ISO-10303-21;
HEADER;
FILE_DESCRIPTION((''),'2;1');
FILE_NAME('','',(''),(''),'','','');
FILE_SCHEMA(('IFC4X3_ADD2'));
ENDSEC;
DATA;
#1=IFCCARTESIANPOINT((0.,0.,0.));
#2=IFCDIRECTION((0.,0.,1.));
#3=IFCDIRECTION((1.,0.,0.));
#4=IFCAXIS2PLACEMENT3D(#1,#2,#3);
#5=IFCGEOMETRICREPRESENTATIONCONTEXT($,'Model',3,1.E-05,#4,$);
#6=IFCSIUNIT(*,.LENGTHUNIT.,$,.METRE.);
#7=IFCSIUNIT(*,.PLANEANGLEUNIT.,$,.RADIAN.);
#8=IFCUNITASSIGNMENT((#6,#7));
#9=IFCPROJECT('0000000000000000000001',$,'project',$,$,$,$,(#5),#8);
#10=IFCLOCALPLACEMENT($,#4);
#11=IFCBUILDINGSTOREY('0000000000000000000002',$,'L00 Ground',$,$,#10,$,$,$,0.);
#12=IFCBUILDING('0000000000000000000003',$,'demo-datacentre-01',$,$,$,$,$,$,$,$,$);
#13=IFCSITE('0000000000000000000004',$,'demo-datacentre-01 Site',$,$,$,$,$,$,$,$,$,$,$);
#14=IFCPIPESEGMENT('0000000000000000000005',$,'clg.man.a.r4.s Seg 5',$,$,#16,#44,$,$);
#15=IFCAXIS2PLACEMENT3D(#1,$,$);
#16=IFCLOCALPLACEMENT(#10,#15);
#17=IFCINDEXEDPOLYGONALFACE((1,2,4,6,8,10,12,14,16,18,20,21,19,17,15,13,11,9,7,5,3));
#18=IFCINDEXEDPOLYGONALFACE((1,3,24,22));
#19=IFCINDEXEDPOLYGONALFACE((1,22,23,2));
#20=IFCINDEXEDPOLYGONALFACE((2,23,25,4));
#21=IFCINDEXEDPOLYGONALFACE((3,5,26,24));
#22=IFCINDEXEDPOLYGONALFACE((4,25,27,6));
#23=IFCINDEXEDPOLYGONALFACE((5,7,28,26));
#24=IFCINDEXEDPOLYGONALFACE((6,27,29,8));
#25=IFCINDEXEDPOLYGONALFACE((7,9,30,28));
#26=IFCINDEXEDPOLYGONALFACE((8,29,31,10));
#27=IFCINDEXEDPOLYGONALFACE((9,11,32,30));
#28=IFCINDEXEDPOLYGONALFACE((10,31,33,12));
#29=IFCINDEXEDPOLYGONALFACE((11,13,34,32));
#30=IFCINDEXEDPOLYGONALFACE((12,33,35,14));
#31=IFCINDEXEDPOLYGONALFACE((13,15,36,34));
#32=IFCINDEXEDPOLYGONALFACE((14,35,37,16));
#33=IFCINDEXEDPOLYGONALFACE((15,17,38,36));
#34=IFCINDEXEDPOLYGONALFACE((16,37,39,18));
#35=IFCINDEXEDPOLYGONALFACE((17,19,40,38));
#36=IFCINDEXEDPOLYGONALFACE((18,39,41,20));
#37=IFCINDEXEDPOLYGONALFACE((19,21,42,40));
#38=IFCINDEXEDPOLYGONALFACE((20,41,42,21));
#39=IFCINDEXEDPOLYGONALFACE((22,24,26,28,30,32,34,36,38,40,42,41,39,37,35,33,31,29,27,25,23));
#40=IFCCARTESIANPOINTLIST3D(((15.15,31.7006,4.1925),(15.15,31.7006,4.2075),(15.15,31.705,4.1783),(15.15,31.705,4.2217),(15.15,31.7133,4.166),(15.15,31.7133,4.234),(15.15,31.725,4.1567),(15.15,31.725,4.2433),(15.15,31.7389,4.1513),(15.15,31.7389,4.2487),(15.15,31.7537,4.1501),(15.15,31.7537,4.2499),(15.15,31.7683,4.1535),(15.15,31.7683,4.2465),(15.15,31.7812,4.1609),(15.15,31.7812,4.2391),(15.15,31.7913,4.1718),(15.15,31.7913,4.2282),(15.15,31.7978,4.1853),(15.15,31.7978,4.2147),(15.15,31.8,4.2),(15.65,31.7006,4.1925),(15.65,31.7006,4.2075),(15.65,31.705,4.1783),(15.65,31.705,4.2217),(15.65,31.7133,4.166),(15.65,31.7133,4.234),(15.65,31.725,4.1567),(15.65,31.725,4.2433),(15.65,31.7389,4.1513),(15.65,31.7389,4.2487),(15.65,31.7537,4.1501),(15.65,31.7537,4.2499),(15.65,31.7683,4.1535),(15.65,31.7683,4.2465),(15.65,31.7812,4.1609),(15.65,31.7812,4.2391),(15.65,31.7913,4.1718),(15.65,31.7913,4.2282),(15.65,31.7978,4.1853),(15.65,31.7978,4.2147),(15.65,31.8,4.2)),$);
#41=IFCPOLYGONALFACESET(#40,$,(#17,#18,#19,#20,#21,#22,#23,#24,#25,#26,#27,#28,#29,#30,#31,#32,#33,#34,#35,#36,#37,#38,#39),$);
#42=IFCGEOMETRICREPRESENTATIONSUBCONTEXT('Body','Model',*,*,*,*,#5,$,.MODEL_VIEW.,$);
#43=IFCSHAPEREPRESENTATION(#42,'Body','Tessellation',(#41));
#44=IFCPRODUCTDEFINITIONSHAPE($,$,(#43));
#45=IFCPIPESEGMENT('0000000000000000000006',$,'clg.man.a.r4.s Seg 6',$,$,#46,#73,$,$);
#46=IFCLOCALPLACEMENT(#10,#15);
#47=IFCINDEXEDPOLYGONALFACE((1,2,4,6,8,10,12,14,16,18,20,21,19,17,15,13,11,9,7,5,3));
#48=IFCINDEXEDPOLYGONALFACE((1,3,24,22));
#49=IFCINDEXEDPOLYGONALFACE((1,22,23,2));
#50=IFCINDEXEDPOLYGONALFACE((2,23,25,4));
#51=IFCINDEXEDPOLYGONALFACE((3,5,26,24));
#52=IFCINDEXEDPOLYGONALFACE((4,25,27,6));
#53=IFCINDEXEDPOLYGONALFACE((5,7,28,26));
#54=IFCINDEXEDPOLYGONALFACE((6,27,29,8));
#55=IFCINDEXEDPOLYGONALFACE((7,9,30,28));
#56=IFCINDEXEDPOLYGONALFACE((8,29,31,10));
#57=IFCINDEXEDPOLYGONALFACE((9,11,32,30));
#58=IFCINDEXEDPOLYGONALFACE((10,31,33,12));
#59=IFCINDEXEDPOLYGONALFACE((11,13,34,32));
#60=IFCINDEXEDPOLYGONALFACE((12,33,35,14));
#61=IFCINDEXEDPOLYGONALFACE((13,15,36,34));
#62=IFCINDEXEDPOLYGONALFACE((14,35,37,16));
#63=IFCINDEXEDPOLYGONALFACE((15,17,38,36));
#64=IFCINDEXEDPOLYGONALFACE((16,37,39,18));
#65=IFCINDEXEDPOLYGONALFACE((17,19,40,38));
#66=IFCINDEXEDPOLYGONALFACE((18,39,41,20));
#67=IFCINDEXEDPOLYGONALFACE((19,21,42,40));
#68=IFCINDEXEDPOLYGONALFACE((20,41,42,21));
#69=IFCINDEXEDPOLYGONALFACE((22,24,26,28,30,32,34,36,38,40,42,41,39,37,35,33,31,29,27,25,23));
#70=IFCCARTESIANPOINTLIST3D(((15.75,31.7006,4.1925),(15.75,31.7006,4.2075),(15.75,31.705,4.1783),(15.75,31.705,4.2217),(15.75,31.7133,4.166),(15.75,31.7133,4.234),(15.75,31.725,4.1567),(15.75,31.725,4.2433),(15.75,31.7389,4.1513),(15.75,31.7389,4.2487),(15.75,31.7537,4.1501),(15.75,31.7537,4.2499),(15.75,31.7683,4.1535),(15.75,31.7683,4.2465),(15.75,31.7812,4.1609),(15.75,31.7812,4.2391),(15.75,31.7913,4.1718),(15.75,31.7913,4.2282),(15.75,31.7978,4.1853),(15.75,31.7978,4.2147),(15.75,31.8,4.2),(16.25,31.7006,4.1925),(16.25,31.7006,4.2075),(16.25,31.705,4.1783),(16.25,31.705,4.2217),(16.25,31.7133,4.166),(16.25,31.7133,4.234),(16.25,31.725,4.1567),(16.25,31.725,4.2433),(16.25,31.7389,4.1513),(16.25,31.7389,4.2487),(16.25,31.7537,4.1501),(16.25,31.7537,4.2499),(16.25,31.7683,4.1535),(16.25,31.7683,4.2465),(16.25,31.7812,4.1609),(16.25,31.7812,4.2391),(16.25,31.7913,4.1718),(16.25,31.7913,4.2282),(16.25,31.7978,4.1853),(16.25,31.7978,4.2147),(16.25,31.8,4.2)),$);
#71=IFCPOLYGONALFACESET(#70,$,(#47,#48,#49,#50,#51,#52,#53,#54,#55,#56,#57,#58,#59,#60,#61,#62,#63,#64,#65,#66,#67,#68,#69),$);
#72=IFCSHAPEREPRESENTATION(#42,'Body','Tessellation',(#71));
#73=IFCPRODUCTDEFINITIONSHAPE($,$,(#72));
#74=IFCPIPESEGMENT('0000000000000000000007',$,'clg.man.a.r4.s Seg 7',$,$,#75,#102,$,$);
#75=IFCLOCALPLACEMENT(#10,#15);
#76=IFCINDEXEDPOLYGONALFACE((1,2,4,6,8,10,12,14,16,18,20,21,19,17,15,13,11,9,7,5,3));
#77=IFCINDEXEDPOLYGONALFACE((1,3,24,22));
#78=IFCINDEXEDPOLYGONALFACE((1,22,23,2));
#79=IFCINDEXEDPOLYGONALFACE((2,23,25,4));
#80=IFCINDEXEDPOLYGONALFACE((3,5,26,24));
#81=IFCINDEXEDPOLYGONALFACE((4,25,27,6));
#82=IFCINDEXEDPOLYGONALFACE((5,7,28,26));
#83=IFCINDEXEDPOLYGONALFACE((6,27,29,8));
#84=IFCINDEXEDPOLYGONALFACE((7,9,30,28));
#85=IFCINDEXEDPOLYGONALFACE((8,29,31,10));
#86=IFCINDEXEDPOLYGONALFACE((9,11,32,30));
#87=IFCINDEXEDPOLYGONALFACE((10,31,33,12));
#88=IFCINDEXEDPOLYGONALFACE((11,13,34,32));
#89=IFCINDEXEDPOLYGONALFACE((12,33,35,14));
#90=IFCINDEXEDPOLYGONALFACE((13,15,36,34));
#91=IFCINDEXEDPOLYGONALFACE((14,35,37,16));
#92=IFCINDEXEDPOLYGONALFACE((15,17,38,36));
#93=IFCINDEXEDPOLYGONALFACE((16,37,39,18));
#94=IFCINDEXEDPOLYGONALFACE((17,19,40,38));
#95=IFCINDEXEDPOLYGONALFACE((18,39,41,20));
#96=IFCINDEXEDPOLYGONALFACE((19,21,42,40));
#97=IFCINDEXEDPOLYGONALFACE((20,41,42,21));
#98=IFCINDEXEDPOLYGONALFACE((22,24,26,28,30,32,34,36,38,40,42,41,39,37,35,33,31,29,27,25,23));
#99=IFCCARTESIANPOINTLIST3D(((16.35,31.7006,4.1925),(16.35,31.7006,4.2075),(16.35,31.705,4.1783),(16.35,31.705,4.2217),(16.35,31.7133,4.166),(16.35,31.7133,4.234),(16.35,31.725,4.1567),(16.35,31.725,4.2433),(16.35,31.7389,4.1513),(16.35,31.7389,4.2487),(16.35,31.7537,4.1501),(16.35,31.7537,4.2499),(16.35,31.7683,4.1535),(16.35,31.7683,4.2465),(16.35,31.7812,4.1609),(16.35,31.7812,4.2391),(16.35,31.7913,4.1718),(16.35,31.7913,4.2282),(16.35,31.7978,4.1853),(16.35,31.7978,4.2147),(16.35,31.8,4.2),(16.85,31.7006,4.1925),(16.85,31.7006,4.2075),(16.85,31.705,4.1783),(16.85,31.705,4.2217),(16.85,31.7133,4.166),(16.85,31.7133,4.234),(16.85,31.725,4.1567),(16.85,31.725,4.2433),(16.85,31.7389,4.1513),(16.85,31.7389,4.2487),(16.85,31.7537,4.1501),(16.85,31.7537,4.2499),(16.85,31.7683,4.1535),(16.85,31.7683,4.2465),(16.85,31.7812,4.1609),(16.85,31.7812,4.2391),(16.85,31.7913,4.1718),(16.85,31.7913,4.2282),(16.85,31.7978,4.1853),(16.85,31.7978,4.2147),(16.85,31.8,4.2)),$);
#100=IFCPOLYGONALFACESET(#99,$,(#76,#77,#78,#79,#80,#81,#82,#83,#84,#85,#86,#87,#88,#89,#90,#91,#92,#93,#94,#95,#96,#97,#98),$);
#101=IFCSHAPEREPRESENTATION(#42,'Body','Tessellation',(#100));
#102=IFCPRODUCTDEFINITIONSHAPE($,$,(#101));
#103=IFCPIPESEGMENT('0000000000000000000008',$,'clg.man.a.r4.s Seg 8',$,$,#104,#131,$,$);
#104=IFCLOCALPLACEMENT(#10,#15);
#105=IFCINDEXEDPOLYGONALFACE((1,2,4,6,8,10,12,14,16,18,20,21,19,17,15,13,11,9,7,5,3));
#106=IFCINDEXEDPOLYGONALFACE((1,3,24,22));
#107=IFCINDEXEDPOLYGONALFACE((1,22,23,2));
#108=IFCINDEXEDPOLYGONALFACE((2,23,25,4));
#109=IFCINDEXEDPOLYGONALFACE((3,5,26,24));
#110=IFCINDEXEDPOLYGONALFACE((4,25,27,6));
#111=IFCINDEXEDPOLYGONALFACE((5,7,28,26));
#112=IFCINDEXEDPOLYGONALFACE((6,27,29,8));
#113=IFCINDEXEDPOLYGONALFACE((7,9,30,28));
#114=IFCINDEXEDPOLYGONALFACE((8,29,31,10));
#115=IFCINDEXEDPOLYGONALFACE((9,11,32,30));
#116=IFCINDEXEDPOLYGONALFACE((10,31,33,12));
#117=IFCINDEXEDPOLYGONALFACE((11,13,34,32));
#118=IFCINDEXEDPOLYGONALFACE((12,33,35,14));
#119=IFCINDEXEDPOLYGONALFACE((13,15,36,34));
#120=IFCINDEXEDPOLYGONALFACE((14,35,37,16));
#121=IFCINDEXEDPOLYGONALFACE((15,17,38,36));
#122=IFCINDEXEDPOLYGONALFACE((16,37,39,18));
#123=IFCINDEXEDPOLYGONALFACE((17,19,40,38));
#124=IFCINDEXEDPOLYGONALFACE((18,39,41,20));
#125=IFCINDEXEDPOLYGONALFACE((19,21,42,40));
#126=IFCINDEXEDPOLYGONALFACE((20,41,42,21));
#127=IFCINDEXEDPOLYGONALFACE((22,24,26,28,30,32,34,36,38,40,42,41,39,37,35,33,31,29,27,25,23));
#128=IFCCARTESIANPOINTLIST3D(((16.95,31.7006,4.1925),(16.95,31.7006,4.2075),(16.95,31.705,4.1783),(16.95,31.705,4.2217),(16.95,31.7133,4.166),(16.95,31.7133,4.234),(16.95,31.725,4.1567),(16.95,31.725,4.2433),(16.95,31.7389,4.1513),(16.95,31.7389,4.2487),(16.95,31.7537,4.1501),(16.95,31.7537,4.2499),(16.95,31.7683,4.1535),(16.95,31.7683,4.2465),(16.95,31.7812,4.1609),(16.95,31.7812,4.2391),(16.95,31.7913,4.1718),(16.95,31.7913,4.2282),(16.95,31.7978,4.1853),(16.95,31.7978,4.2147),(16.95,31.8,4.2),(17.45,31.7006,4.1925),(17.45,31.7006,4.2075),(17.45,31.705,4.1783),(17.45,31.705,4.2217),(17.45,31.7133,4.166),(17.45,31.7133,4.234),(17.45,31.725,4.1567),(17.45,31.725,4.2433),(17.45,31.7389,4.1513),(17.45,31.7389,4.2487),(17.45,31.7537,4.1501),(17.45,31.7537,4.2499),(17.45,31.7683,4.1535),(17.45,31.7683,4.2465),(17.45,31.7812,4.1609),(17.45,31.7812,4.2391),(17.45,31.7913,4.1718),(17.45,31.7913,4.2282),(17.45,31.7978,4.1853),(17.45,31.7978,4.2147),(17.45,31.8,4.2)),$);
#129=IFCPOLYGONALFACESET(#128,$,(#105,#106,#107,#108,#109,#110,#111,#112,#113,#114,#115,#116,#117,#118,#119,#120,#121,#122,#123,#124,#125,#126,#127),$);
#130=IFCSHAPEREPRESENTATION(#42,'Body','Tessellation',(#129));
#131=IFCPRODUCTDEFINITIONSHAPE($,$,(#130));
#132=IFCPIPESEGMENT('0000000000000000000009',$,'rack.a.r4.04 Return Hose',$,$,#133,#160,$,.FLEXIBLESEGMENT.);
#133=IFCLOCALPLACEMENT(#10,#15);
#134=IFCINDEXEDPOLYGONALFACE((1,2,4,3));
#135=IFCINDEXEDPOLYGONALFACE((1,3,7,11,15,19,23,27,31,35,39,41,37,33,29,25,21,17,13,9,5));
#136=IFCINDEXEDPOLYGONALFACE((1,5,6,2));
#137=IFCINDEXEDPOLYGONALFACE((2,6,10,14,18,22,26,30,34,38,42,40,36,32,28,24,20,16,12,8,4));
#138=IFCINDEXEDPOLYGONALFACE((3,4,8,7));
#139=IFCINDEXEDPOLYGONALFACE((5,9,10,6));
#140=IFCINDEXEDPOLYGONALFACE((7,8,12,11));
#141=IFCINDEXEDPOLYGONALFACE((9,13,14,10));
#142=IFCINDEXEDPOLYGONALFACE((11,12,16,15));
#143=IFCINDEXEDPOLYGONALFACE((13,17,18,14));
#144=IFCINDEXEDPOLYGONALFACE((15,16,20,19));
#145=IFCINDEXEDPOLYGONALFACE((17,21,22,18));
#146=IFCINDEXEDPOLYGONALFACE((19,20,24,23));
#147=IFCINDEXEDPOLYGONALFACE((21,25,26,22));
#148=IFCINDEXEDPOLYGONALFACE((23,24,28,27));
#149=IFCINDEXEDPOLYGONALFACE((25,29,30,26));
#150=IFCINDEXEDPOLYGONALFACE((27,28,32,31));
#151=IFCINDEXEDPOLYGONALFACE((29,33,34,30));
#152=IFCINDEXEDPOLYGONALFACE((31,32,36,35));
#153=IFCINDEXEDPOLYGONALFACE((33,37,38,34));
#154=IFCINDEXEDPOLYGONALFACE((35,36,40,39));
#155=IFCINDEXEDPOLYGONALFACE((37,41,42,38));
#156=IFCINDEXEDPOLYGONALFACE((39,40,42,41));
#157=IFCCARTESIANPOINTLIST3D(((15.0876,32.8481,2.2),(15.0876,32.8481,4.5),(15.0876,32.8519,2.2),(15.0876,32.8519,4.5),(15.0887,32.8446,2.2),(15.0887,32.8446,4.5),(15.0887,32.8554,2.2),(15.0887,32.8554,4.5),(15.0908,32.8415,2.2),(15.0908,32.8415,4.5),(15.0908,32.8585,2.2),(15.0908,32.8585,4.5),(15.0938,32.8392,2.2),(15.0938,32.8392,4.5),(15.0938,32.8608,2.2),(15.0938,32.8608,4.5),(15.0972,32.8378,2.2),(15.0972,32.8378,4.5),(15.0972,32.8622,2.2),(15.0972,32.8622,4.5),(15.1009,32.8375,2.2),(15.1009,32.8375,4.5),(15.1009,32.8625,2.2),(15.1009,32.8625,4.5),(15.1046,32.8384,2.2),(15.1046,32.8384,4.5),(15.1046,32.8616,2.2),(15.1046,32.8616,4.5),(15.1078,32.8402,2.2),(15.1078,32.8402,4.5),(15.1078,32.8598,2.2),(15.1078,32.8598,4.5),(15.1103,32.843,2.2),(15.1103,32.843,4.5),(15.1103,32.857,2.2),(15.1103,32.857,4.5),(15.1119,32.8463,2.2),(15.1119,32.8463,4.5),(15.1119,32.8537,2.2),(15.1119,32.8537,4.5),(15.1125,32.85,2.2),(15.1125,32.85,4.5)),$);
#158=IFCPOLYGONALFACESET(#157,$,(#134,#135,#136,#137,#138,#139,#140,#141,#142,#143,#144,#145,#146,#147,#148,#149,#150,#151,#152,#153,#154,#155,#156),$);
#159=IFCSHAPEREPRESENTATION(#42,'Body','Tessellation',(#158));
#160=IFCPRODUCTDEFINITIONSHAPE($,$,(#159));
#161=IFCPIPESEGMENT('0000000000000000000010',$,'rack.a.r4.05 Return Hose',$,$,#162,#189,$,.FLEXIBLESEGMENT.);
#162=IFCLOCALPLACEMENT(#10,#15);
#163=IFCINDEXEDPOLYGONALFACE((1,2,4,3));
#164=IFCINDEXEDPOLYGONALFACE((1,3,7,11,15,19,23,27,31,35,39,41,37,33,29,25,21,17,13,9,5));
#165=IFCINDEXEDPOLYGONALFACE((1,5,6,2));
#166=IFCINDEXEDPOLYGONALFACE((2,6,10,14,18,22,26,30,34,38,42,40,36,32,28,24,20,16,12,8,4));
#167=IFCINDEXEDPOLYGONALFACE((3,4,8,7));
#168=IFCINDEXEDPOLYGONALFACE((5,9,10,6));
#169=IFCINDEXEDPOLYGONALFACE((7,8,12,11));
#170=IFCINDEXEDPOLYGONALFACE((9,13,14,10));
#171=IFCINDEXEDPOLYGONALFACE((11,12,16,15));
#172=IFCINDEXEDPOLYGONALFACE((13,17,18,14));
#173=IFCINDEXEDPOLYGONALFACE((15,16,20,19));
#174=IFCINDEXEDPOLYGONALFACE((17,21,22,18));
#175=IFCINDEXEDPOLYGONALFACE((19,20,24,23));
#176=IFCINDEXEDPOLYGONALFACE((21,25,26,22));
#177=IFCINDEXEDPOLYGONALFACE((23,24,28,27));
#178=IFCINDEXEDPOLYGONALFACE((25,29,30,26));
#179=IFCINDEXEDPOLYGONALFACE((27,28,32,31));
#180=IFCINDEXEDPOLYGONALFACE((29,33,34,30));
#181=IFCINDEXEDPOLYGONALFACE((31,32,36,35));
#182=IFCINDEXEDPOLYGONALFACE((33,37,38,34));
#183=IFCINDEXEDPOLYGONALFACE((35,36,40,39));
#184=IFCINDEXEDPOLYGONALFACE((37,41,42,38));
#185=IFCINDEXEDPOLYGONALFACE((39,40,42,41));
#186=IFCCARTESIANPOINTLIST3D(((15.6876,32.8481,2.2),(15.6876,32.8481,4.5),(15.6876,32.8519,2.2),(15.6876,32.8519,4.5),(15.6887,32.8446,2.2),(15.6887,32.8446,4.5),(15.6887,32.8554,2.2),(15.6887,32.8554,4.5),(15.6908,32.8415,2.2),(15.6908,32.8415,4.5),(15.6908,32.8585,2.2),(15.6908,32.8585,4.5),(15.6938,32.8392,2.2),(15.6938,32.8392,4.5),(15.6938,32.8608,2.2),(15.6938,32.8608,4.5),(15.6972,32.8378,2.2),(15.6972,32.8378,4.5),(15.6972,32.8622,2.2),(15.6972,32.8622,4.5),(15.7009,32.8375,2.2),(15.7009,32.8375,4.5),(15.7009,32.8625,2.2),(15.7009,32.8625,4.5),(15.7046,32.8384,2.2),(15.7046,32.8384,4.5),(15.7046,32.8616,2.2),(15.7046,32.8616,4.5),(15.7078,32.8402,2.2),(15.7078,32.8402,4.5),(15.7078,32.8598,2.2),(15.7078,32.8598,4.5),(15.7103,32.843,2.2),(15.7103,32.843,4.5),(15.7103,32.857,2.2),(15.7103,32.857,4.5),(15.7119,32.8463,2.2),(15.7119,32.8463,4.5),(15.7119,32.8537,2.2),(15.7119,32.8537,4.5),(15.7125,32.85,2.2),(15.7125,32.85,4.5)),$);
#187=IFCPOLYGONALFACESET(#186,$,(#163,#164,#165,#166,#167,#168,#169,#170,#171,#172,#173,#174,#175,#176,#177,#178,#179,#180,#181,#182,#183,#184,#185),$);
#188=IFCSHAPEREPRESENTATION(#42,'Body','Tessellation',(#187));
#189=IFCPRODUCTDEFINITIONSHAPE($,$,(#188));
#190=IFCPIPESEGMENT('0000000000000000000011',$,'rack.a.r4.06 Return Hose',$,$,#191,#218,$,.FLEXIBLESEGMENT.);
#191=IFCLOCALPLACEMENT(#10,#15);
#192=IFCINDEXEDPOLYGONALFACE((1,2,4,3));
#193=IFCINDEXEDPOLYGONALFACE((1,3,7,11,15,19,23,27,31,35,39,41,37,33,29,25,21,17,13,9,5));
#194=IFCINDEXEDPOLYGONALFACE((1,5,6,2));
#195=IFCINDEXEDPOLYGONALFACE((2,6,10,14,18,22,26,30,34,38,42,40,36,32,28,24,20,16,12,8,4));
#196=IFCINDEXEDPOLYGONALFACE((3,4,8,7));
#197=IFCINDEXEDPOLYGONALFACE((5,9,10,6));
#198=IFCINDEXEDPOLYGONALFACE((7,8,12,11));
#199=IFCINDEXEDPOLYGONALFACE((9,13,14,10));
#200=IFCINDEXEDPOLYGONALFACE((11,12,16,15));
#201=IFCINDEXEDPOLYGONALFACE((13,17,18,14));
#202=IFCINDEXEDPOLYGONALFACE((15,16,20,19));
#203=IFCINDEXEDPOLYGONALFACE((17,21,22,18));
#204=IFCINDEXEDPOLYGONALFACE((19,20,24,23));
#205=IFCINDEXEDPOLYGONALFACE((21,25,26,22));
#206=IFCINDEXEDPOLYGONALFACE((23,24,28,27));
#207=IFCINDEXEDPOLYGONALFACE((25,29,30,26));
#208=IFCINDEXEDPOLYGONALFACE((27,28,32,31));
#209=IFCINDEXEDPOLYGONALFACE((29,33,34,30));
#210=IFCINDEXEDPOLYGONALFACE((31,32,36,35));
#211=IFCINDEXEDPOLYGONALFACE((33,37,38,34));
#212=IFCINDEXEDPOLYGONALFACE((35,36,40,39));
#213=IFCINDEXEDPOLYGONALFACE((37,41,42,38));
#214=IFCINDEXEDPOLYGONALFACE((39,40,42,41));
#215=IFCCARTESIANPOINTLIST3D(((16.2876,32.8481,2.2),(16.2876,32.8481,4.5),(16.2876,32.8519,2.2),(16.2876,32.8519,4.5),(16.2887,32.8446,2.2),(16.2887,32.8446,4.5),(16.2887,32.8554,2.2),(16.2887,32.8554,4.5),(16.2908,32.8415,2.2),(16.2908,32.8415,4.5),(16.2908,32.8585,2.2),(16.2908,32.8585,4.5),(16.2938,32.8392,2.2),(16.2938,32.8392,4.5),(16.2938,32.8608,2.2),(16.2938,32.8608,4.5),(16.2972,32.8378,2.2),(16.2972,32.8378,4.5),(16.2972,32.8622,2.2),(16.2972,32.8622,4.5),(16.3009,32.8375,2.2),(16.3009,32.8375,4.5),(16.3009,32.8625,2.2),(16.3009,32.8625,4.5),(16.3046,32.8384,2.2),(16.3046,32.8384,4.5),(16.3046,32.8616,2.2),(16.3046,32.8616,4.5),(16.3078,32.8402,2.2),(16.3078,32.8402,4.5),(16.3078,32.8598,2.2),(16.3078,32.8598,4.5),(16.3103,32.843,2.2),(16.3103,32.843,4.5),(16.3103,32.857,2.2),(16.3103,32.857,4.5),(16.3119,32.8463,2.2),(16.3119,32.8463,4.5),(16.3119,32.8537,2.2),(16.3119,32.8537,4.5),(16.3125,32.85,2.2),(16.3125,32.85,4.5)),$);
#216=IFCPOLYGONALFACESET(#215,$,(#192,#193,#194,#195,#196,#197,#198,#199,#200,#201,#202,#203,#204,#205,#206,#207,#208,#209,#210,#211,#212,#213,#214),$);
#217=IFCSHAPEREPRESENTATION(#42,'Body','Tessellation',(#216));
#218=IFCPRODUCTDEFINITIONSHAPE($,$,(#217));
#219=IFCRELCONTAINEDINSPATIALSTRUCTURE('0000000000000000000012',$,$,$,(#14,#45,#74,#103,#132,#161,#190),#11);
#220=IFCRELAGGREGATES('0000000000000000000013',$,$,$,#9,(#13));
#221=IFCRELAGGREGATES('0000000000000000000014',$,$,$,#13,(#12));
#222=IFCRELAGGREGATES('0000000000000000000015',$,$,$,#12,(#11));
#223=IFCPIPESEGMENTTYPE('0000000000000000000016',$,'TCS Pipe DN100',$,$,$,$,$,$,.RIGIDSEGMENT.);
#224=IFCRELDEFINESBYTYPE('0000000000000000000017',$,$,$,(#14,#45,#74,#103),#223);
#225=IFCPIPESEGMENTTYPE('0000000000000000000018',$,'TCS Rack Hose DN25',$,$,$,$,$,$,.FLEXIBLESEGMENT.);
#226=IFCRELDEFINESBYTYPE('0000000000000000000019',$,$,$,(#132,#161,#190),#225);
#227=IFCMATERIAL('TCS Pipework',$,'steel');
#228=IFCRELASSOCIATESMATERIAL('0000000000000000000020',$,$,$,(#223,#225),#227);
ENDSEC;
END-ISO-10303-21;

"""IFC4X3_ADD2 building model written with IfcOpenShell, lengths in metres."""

from ifc_helpers import new_model, si_unit, frame, origin_with_axes, place, context, subcontext, project, spatial, circle, extrude, material, type_object, element, save


model = new_model("IFC4X3_ADD2")

# Units and contexts
model_context = context("Model", 3, precision=1e-05, world=origin_with_axes())
body_context = subcontext(model_context, "Body", "Model", "MODEL_VIEW")
ifc_project = project(units=[si_unit("LENGTHUNIT", "METRE"), si_unit("PLANEANGLEUNIT", "RADIAN")], contexts=[model_context])

# Site, building, storey
site = spatial("IfcSite", under=ifc_project, Name="demo-datacentre-01 Site")
building = spatial("IfcBuilding", under=site, Name="demo-datacentre-01")
storey_placement = place(None, origin_with_axes())
storey = spatial("IfcBuildingStorey", under=building, at=storey_placement, Name="L00 Ground", Elevation=0.0)

# Shared definitions
ifc_material = material(Name="TCS Pipework", Category="steel")

# Pipe segments
pipe_segment_type_1 = type_object("IfcPipeSegmentType", Name="TCS Pipe DN100", PredefinedType="RIGIDSEGMENT", material=ifc_material)
for number, where, z_axis, x_axis, name in (
    (1, (15.15, 31.75, 4.2), (1.0, 0.0, 0.0), (0.0, 1.0, 0.0), "clg.man.a.r4.s Seg 5"),
    (2, (15.75, 31.75, 4.2), (1.0, 0.0, 0.0), (0.0, 1.0, 0.0), "clg.man.a.r4.s Seg 6"),
):
    element("IfcPipeSegment", number, at=place(storey_placement, frame(where, z_axis=z_axis, x_axis=x_axis)), inside=storey, type_object=pipe_segment_type_1, Name=name, context=body_context, shape_type="SweptSolid", body=[
        extrude(circle(Radius=0.05), origin_with_axes(), (0.0, 0.0, 1.0), 0.5),
    ])
pipe_segment_1_placement = place(storey_placement, frame((16.35, 31.75, 4.2), z_axis=(1.0, 0.0, 0.0), x_axis=(0.0, 1.0, 0.0)))
element("IfcPipeSegment", 3, at=pipe_segment_1_placement, inside=storey, type_object=pipe_segment_type_1, Name="clg.man.a.r4.s Seg 7", context=body_context, shape_type="SweptSolid", body=[
    extrude(circle(Radius=0.05), origin_with_axes(), (0.0, 0.0, 1.0), 0.5),
])
pipe_segment_2_placement = place(storey_placement, frame((16.95, 31.75, 4.2), z_axis=(1.0, 0.0, 0.0), x_axis=(0.0, 1.0, 0.0)))
element("IfcPipeSegment", 4, at=pipe_segment_2_placement, inside=storey, type_object=pipe_segment_type_1, Name="clg.man.a.r4.s Seg 8", context=body_context, shape_type="SweptSolid", body=[
    extrude(circle(Radius=0.05), origin_with_axes(), (0.0, 0.0, 1.0), 0.5),
])
pipe_segment_type_2 = type_object("IfcPipeSegmentType", Name="TCS Rack Hose DN25", PredefinedType="FLEXIBLESEGMENT", material=ifc_material)
for number, where, z_axis, x_axis, name in (
    (5, (15.1, 32.85, 4.5), (0.0, 0.0, -1.0), (1.0, 0.0, 0.0), "rack.a.r4.04 Return Hose"),
    (6, (15.7, 32.85, 4.5), (0.0, 0.0, -1.0), (1.0, 0.0, 0.0), "rack.a.r4.05 Return Hose"),
    (7, (16.3, 32.85, 4.5), (0.0, 0.0, -1.0), (1.0, 0.0, 0.0), "rack.a.r4.06 Return Hose"),
):
    element("IfcPipeSegment", number, at=place(storey_placement, frame(where, z_axis=z_axis, x_axis=x_axis)), inside=storey, type_object=pipe_segment_type_2, Name=name, PredefinedType="FLEXIBLESEGMENT", context=body_context, shape_type="SweptSolid", body=[
        extrude(circle(Radius=0.0125), origin_with_axes(), (0.0, 0.0, 1.0), 2.3),
    ])

save(model, "model.ifc")
